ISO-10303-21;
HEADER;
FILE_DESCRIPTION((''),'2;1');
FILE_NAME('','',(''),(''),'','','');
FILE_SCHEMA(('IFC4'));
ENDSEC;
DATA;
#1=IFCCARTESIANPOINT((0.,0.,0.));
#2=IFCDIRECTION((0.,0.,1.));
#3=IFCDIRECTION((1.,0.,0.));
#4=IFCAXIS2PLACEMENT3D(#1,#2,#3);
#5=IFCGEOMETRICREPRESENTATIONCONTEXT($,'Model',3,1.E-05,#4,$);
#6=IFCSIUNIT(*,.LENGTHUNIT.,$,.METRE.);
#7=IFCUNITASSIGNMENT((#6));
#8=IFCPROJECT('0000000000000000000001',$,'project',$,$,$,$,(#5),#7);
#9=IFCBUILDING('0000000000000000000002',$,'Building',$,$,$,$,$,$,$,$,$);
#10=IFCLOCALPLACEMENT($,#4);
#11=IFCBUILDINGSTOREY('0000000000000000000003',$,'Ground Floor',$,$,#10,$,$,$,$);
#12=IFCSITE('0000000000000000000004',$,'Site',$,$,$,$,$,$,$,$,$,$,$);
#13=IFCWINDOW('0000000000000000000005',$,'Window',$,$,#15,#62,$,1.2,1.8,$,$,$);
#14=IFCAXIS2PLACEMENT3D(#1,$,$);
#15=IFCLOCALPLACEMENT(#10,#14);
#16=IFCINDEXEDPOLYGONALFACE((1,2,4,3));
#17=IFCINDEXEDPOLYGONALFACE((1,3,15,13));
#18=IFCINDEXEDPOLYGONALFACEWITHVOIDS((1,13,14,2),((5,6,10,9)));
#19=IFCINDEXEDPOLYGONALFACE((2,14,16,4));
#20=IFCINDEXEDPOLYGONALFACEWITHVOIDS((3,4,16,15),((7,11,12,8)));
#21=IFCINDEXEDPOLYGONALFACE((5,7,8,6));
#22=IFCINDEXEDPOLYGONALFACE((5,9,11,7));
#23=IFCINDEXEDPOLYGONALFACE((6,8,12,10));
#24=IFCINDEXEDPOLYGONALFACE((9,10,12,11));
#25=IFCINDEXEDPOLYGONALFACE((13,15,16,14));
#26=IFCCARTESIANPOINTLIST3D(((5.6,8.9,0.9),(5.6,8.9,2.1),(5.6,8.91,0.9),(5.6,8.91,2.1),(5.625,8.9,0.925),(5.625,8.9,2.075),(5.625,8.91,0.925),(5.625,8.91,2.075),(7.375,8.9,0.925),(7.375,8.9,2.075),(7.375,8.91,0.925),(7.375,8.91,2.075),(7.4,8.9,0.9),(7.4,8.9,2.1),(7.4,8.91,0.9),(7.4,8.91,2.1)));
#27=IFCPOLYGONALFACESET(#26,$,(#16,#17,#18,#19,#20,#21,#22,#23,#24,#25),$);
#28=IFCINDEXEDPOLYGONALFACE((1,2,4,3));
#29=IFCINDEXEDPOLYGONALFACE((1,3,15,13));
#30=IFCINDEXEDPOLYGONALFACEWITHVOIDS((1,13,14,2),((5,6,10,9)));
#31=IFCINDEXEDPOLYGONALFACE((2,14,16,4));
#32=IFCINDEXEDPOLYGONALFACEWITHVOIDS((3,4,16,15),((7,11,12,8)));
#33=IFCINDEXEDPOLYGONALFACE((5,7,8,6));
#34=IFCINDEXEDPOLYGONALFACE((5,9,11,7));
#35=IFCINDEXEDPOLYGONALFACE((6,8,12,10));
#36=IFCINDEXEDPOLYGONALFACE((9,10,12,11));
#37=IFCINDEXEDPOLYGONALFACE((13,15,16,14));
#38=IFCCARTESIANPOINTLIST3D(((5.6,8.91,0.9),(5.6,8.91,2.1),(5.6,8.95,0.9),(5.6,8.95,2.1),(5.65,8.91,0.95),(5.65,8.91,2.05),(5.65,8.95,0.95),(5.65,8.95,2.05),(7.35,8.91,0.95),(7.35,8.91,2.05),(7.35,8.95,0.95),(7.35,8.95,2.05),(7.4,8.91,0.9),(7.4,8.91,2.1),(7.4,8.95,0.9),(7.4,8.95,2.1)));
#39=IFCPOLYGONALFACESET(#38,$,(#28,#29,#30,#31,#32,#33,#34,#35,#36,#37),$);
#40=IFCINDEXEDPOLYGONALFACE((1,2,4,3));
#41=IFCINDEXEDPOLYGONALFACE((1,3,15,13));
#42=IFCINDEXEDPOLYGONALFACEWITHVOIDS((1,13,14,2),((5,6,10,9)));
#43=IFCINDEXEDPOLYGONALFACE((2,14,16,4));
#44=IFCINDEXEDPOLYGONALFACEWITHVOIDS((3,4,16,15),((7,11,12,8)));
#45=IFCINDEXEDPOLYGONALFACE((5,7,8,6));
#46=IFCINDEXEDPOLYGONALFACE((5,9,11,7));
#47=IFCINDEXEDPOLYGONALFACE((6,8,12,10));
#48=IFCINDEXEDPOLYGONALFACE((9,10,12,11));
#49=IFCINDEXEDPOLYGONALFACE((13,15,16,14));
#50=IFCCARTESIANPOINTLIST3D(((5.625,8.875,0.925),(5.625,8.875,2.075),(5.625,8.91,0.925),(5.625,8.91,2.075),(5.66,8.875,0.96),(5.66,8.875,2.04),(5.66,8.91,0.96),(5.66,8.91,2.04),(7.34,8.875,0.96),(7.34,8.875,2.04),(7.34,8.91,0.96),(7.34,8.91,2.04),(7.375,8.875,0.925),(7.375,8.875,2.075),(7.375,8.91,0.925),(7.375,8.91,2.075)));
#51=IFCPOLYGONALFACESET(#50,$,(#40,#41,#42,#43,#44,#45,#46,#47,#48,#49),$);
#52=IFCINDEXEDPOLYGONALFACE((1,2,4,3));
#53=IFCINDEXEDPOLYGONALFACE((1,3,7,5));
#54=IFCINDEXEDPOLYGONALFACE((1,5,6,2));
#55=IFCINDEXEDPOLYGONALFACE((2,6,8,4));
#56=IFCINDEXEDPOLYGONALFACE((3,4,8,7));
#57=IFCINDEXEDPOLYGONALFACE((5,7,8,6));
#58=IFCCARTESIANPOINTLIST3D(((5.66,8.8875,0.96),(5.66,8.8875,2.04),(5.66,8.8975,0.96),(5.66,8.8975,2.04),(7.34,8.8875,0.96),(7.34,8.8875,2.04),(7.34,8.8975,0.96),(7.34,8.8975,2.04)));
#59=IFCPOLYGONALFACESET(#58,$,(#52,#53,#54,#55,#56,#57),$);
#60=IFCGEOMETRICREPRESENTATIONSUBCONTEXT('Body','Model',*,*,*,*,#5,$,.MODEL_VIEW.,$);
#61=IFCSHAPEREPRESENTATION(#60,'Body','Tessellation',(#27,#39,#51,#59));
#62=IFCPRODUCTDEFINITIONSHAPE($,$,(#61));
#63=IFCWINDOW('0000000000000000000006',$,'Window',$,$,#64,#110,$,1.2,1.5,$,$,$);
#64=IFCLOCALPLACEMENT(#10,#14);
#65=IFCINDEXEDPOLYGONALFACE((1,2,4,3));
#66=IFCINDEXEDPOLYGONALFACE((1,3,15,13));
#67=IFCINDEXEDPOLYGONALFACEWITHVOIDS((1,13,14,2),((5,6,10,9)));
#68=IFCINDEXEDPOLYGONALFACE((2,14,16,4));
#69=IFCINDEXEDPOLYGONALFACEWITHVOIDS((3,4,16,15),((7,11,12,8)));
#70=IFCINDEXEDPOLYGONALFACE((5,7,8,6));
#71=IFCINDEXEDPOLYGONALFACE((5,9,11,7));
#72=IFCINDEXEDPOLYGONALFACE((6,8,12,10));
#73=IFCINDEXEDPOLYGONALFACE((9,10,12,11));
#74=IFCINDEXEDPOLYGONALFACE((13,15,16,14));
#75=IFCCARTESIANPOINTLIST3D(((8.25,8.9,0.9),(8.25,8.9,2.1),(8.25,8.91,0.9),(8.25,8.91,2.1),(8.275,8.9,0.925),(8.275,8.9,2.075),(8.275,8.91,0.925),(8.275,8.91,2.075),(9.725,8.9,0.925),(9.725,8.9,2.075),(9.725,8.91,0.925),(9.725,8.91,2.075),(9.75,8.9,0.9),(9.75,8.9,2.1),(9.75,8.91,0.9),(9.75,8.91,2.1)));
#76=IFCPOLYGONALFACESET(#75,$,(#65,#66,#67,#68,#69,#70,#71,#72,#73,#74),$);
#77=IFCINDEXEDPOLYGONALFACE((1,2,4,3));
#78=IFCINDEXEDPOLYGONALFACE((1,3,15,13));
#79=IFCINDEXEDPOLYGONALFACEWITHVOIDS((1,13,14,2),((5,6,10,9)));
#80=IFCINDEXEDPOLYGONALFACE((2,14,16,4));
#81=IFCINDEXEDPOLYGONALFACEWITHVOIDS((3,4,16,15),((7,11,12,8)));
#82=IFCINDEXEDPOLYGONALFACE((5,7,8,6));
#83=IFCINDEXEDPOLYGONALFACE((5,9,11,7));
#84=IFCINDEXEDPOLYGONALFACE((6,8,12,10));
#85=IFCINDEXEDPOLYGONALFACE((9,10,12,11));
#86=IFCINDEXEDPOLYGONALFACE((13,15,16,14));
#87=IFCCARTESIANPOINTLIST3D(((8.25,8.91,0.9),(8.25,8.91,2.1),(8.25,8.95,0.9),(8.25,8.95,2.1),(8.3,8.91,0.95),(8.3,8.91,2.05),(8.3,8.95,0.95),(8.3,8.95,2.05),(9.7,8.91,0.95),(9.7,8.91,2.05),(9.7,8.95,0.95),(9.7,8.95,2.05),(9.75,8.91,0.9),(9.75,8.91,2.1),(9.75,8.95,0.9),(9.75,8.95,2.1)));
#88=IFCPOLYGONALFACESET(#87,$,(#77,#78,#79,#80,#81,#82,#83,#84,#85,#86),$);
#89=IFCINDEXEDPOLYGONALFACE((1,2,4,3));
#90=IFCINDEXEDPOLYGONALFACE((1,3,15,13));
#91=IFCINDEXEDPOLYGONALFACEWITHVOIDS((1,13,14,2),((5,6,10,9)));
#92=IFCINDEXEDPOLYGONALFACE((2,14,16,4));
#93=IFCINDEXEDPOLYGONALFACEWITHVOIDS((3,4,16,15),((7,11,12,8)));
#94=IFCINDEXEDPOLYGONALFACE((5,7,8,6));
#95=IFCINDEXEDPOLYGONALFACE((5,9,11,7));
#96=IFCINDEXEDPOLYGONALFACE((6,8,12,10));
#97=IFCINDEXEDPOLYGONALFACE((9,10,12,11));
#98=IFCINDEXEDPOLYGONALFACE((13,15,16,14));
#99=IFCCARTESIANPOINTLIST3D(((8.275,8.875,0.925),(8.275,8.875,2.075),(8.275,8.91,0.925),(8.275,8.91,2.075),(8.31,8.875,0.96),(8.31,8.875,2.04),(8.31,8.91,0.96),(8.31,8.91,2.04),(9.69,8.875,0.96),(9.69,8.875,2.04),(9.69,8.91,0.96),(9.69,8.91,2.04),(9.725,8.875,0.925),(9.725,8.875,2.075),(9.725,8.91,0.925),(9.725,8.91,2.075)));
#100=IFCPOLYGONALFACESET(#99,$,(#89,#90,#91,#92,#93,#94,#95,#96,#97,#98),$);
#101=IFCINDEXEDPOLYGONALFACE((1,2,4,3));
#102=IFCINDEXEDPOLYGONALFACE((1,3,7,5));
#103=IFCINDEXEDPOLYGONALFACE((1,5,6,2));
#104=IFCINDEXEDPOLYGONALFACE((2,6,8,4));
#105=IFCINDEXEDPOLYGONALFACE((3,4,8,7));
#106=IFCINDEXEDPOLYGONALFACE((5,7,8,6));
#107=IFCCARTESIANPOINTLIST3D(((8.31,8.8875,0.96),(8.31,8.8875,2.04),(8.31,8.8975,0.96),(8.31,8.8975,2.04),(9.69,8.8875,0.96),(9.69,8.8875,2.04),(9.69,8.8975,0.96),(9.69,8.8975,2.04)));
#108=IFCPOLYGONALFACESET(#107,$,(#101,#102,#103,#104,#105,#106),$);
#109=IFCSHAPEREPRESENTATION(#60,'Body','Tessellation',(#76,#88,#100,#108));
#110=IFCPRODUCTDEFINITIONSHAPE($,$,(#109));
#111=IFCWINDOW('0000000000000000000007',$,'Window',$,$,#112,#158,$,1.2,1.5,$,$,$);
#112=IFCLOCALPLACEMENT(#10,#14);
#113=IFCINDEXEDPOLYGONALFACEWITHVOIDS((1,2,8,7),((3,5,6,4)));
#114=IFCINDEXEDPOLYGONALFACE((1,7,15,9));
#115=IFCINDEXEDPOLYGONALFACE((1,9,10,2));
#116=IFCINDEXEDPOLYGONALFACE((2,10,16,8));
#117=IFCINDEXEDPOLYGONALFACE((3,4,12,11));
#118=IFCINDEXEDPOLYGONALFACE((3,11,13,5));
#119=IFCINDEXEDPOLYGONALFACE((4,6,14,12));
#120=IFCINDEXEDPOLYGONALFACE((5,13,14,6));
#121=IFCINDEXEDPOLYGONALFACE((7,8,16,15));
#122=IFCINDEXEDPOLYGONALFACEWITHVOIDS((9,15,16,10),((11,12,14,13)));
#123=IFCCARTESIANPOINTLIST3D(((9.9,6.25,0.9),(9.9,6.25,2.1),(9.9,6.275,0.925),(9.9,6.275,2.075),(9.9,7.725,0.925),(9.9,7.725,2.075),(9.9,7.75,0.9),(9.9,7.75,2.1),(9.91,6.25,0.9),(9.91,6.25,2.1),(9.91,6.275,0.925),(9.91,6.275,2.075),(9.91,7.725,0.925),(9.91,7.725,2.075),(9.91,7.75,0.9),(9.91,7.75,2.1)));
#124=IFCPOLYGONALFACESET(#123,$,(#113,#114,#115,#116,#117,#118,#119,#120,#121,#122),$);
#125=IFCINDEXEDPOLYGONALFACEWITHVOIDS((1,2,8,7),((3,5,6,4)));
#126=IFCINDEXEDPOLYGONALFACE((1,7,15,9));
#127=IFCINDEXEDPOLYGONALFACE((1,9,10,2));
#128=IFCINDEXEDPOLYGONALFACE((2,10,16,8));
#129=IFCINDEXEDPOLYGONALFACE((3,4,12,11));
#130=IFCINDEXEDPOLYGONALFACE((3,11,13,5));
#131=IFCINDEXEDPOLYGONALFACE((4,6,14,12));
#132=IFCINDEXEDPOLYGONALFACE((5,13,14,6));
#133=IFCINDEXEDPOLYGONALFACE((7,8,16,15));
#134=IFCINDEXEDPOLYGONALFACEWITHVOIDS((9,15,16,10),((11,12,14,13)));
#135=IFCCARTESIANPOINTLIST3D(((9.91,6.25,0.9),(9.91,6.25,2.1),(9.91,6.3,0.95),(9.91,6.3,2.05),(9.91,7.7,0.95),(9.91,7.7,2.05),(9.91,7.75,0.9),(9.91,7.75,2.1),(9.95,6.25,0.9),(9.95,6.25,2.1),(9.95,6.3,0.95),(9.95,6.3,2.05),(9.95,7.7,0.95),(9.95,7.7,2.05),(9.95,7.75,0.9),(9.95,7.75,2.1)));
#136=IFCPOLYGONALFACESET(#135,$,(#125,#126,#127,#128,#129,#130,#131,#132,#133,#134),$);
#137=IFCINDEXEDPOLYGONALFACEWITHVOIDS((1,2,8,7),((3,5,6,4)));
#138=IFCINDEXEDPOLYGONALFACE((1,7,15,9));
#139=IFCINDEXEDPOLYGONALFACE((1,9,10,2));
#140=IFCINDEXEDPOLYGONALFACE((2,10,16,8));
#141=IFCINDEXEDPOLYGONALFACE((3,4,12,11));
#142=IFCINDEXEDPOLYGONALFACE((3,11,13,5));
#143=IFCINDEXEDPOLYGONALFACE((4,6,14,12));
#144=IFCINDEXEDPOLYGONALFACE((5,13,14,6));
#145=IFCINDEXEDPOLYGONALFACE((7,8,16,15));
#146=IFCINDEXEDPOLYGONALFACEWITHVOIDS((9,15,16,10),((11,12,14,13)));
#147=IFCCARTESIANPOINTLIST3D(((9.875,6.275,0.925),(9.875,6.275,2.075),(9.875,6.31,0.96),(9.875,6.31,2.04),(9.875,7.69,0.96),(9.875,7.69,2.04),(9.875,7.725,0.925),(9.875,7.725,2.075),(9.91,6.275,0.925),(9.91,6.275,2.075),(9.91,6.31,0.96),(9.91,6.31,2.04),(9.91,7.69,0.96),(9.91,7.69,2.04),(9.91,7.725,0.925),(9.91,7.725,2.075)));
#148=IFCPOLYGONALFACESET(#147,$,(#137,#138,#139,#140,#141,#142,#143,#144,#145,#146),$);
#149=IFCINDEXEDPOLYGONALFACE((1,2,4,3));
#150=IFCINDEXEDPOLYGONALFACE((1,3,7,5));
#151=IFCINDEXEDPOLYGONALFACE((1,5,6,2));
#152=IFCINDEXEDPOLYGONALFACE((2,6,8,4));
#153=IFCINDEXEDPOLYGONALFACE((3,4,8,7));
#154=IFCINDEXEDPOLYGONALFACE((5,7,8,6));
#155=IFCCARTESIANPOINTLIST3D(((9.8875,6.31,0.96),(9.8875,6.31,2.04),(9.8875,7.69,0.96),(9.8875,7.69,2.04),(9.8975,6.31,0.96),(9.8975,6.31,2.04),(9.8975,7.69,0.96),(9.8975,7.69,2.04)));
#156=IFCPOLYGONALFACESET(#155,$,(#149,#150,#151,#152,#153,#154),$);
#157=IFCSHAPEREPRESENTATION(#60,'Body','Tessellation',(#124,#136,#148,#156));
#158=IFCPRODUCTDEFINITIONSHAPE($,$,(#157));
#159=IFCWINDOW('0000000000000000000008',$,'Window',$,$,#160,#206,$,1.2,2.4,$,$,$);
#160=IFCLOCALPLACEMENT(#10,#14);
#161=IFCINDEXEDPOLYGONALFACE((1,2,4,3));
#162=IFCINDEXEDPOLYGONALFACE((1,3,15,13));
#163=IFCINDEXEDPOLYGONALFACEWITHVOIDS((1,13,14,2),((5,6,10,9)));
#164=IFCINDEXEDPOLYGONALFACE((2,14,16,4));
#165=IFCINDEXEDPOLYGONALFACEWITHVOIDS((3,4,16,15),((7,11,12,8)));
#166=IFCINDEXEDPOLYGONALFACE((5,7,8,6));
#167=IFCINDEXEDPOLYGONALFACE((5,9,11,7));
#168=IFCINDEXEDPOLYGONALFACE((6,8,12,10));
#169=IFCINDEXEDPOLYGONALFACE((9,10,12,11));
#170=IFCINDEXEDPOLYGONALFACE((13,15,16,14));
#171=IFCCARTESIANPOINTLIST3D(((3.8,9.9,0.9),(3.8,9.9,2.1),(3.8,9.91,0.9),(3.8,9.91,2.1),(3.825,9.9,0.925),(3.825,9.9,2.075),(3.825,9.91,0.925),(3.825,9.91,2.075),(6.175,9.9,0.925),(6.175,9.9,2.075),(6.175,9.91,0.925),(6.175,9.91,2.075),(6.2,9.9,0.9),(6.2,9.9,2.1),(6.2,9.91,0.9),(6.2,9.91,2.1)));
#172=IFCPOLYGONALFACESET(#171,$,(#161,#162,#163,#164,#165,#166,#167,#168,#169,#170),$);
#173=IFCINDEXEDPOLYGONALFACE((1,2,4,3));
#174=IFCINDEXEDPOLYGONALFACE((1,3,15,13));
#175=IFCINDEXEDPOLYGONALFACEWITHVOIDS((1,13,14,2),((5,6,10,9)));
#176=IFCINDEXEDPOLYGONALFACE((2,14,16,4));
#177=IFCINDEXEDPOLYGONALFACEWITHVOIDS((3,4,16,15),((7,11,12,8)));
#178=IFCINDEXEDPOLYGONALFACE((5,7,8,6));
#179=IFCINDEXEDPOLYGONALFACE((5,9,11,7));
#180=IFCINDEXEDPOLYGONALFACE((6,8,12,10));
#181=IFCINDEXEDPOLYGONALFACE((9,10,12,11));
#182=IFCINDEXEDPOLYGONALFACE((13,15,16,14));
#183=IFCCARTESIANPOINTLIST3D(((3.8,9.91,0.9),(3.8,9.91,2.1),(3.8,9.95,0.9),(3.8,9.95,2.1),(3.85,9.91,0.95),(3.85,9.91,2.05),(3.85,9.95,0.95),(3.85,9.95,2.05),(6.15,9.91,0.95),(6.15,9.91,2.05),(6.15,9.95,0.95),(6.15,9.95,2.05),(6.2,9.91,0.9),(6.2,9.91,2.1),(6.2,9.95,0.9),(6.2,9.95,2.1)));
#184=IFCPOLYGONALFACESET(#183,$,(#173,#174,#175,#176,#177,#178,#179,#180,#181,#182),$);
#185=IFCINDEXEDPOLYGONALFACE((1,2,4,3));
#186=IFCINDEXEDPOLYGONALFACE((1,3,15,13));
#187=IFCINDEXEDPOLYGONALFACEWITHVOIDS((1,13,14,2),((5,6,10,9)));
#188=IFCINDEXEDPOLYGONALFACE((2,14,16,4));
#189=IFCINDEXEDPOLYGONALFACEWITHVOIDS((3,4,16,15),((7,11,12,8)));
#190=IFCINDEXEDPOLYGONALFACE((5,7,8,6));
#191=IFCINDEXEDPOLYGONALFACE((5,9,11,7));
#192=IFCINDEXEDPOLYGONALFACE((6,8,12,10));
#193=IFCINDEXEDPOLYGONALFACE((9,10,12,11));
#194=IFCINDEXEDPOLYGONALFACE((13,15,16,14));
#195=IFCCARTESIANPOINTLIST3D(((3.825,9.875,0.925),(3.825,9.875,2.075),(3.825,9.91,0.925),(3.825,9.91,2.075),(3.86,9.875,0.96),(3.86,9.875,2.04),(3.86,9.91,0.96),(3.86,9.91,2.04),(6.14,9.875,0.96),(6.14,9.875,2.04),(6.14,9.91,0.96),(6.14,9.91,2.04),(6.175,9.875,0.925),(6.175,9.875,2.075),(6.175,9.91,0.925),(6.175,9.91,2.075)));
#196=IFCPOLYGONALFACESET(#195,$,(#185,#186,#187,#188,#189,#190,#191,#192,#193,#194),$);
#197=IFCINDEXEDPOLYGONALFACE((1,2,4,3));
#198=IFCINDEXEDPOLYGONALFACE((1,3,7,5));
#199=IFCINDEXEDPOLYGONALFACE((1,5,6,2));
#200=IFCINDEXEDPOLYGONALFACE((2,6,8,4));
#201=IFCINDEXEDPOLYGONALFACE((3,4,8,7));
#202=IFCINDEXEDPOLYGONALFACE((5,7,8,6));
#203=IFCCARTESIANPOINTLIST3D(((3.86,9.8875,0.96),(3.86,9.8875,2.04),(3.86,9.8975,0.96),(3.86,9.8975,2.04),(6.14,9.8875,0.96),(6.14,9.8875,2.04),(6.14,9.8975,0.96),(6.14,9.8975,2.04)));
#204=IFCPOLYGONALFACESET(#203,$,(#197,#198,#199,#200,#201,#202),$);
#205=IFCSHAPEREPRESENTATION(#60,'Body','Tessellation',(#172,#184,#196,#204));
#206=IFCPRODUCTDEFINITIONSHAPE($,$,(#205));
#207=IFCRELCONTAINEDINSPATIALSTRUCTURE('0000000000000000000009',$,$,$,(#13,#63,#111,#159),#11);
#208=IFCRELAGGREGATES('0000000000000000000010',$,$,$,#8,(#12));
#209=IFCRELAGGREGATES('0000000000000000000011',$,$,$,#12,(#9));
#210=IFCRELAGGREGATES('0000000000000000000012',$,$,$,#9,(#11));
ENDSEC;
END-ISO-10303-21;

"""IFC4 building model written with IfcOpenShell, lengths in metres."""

from ifc_helpers import new_model, si_unit, frame, origin_with_axes, place, context, subcontext, project, spatial, line, indexed_curve, outline, extrude, element, save


model = new_model("IFC4")

# Units and contexts
model_context = context("Model", 3, precision=1e-05, world=origin_with_axes())
body_context = subcontext(model_context, "Body", "Model", "MODEL_VIEW")
ifc_project = project(units=[si_unit("LENGTHUNIT", "METRE")], contexts=[model_context])

# Site, building, storey
site = spatial("IfcSite", under=ifc_project, Name="Site")
building = spatial("IfcBuilding", under=site, Name="Building")
storey_placement = place(None, origin_with_axes())
storey = spatial("IfcBuildingStorey", under=building, at=storey_placement, Name="Ground Floor")

# Windows
window_1_placement = place(storey_placement, frame((7.4, 9.0, 0.9), z_axis=(0.0, 0.0, 1.0), x_axis=(-1.0, 0.0, 0.0)))
element("IfcWindow", 1, at=window_1_placement, inside=storey, Name="Window", OverallHeight=1.2, OverallWidth=1.8, context=body_context, shape_type="SweptSolid", body=[
    extrude(outline(indexed_curve([(0.0, 0.0), (1.8, 0.0), (1.8, 1.2), (0.0, 1.2)], segments=[line(1, 2, 3, 4, 1)]), holes=[indexed_curve([(0.025, 0.025), (1.775, 0.025), (1.775, 1.175), (0.025, 1.175)], segments=[line(1, 2, 3, 4, 1)])]), frame((0.0, 0.09, 0.0), z_axis=(0.0, -1.0, 0.0), x_axis=(1.0, 0.0, 0.0)), (0.0, 0.0, -1.0), 0.01),
    extrude(outline(indexed_curve([(0.0, 0.0), (1.8, 0.0), (1.8, 1.2), (0.0, 1.2)], segments=[line(1, 2, 3, 4, 1)]), holes=[indexed_curve([(0.05, 0.05), (1.75, 0.05), (1.75, 1.15), (0.05, 1.15)], segments=[line(1, 2, 3, 4, 1)])]), frame((0.0, 0.05, 0.0), z_axis=(0.0, -1.0, 0.0), x_axis=(1.0, 0.0, 0.0)), (0.0, 0.0, -1.0), 0.04),
    extrude(outline(indexed_curve([(0.0, 0.0), (1.75, 0.0), (1.75, 1.15), (0.0, 1.15)], segments=[line(1, 2, 3, 4, 1)]), holes=[indexed_curve([(0.035, 0.035), (1.715, 0.035), (1.715, 1.115), (0.035, 1.115)], segments=[line(1, 2, 3, 4, 1)])]), frame((0.025, 0.09, 0.025), z_axis=(0.0, -1.0, 0.0), x_axis=(1.0, 0.0, 0.0)), (0.0, 0.0, -1.0), 0.035),
    extrude(outline(indexed_curve([(0.035, 0.035), (1.715, 0.035), (1.715, 1.115), (0.035, 1.115)], segments=[line(1, 2, 3, 4, 1)])), frame((0.025, 0.1025, 0.025), z_axis=(0.0, -1.0, 0.0), x_axis=(1.0, 0.0, 0.0)), (0.0, 0.0, -1.0), 0.01),
])
for number, where, z_axis, x_axis, name in (
    (2, (9.75, 9.0, 0.9), (0.0, 0.0, 1.0), (-1.0, 0.0, 0.0), "Window"),
    (3, (10.0, 6.25, 0.9), (0.0, 0.0, 1.0), (0.0, 1.0, 0.0), "Window"),
):
    element("IfcWindow", number, at=place(storey_placement, frame(where, z_axis=z_axis, x_axis=x_axis)), inside=storey, Name=name, OverallHeight=1.2, OverallWidth=1.5, context=body_context, shape_type="SweptSolid", body=[
        extrude(outline(indexed_curve([(0.0, 0.0), (1.5, 0.0), (1.5, 1.2), (0.0, 1.2)], segments=[line(1, 2, 3, 4, 1)]), holes=[indexed_curve([(0.025, 0.025), (1.475, 0.025), (1.475, 1.175), (0.025, 1.175)], segments=[line(1, 2, 3, 4, 1)])]), frame((0.0, 0.09, 0.0), z_axis=(0.0, -1.0, 0.0), x_axis=(1.0, 0.0, 0.0)), (0.0, 0.0, -1.0), 0.01),
        extrude(outline(indexed_curve([(0.0, 0.0), (1.5, 0.0), (1.5, 1.2), (0.0, 1.2)], segments=[line(1, 2, 3, 4, 1)]), holes=[indexed_curve([(0.05, 0.05), (1.45, 0.05), (1.45, 1.15), (0.05, 1.15)], segments=[line(1, 2, 3, 4, 1)])]), frame((0.0, 0.05, 0.0), z_axis=(0.0, -1.0, 0.0), x_axis=(1.0, 0.0, 0.0)), (0.0, 0.0, -1.0), 0.04),
        extrude(outline(indexed_curve([(0.0, 0.0), (1.45, 0.0), (1.45, 1.15), (0.0, 1.15)], segments=[line(1, 2, 3, 4, 1)]), holes=[indexed_curve([(0.035, 0.035), (1.415, 0.035), (1.415, 1.115), (0.035, 1.115)], segments=[line(1, 2, 3, 4, 1)])]), frame((0.025, 0.09, 0.025), z_axis=(0.0, -1.0, 0.0), x_axis=(1.0, 0.0, 0.0)), (0.0, 0.0, -1.0), 0.035),
        extrude(outline(indexed_curve([(0.035, 0.035), (1.415, 0.035), (1.415, 1.115), (0.035, 1.115)], segments=[line(1, 2, 3, 4, 1)])), frame((0.025, 0.1025, 0.025), z_axis=(0.0, -1.0, 0.0), x_axis=(1.0, 0.0, 0.0)), (0.0, 0.0, -1.0), 0.01),
    ])
window_2_placement = place(storey_placement, frame((6.2, 10.0, 0.9), z_axis=(0.0, 0.0, 1.0), x_axis=(-1.0, 0.0, 0.0)))
element("IfcWindow", 4, at=window_2_placement, inside=storey, Name="Window", OverallHeight=1.2, OverallWidth=2.4, context=body_context, shape_type="SweptSolid", body=[
    extrude(outline(indexed_curve([(0.0, 0.0), (2.4, 0.0), (2.4, 1.2), (0.0, 1.2)], segments=[line(1, 2, 3, 4, 1)]), holes=[indexed_curve([(0.025, 0.025), (2.375, 0.025), (2.375, 1.175), (0.025, 1.175)], segments=[line(1, 2, 3, 4, 1)])]), frame((0.0, 0.09, 0.0), z_axis=(0.0, -1.0, 0.0), x_axis=(1.0, 0.0, 0.0)), (0.0, 0.0, -1.0), 0.01),
    extrude(outline(indexed_curve([(0.0, 0.0), (2.4, 0.0), (2.4, 1.2), (0.0, 1.2)], segments=[line(1, 2, 3, 4, 1)]), holes=[indexed_curve([(0.05, 0.05), (2.35, 0.05), (2.35, 1.15), (0.05, 1.15)], segments=[line(1, 2, 3, 4, 1)])]), frame((0.0, 0.05, 0.0), z_axis=(0.0, -1.0, 0.0), x_axis=(1.0, 0.0, 0.0)), (0.0, 0.0, -1.0), 0.04),
    extrude(outline(indexed_curve([(0.0, 0.0), (2.35, 0.0), (2.35, 1.15), (0.0, 1.15)], segments=[line(1, 2, 3, 4, 1)]), holes=[indexed_curve([(0.035, 0.035), (2.315, 0.035), (2.315, 1.115), (0.035, 1.115)], segments=[line(1, 2, 3, 4, 1)])]), frame((0.025, 0.09, 0.025), z_axis=(0.0, -1.0, 0.0), x_axis=(1.0, 0.0, 0.0)), (0.0, 0.0, -1.0), 0.035),
    extrude(outline(indexed_curve([(0.035, 0.035), (2.315, 0.035), (2.315, 1.115), (0.035, 1.115)], segments=[line(1, 2, 3, 4, 1)])), frame((0.025, 0.1025, 0.025), z_axis=(0.0, -1.0, 0.0), x_axis=(1.0, 0.0, 0.0)), (0.0, 0.0, -1.0), 0.01),
])

save(model, "model.ifc")
